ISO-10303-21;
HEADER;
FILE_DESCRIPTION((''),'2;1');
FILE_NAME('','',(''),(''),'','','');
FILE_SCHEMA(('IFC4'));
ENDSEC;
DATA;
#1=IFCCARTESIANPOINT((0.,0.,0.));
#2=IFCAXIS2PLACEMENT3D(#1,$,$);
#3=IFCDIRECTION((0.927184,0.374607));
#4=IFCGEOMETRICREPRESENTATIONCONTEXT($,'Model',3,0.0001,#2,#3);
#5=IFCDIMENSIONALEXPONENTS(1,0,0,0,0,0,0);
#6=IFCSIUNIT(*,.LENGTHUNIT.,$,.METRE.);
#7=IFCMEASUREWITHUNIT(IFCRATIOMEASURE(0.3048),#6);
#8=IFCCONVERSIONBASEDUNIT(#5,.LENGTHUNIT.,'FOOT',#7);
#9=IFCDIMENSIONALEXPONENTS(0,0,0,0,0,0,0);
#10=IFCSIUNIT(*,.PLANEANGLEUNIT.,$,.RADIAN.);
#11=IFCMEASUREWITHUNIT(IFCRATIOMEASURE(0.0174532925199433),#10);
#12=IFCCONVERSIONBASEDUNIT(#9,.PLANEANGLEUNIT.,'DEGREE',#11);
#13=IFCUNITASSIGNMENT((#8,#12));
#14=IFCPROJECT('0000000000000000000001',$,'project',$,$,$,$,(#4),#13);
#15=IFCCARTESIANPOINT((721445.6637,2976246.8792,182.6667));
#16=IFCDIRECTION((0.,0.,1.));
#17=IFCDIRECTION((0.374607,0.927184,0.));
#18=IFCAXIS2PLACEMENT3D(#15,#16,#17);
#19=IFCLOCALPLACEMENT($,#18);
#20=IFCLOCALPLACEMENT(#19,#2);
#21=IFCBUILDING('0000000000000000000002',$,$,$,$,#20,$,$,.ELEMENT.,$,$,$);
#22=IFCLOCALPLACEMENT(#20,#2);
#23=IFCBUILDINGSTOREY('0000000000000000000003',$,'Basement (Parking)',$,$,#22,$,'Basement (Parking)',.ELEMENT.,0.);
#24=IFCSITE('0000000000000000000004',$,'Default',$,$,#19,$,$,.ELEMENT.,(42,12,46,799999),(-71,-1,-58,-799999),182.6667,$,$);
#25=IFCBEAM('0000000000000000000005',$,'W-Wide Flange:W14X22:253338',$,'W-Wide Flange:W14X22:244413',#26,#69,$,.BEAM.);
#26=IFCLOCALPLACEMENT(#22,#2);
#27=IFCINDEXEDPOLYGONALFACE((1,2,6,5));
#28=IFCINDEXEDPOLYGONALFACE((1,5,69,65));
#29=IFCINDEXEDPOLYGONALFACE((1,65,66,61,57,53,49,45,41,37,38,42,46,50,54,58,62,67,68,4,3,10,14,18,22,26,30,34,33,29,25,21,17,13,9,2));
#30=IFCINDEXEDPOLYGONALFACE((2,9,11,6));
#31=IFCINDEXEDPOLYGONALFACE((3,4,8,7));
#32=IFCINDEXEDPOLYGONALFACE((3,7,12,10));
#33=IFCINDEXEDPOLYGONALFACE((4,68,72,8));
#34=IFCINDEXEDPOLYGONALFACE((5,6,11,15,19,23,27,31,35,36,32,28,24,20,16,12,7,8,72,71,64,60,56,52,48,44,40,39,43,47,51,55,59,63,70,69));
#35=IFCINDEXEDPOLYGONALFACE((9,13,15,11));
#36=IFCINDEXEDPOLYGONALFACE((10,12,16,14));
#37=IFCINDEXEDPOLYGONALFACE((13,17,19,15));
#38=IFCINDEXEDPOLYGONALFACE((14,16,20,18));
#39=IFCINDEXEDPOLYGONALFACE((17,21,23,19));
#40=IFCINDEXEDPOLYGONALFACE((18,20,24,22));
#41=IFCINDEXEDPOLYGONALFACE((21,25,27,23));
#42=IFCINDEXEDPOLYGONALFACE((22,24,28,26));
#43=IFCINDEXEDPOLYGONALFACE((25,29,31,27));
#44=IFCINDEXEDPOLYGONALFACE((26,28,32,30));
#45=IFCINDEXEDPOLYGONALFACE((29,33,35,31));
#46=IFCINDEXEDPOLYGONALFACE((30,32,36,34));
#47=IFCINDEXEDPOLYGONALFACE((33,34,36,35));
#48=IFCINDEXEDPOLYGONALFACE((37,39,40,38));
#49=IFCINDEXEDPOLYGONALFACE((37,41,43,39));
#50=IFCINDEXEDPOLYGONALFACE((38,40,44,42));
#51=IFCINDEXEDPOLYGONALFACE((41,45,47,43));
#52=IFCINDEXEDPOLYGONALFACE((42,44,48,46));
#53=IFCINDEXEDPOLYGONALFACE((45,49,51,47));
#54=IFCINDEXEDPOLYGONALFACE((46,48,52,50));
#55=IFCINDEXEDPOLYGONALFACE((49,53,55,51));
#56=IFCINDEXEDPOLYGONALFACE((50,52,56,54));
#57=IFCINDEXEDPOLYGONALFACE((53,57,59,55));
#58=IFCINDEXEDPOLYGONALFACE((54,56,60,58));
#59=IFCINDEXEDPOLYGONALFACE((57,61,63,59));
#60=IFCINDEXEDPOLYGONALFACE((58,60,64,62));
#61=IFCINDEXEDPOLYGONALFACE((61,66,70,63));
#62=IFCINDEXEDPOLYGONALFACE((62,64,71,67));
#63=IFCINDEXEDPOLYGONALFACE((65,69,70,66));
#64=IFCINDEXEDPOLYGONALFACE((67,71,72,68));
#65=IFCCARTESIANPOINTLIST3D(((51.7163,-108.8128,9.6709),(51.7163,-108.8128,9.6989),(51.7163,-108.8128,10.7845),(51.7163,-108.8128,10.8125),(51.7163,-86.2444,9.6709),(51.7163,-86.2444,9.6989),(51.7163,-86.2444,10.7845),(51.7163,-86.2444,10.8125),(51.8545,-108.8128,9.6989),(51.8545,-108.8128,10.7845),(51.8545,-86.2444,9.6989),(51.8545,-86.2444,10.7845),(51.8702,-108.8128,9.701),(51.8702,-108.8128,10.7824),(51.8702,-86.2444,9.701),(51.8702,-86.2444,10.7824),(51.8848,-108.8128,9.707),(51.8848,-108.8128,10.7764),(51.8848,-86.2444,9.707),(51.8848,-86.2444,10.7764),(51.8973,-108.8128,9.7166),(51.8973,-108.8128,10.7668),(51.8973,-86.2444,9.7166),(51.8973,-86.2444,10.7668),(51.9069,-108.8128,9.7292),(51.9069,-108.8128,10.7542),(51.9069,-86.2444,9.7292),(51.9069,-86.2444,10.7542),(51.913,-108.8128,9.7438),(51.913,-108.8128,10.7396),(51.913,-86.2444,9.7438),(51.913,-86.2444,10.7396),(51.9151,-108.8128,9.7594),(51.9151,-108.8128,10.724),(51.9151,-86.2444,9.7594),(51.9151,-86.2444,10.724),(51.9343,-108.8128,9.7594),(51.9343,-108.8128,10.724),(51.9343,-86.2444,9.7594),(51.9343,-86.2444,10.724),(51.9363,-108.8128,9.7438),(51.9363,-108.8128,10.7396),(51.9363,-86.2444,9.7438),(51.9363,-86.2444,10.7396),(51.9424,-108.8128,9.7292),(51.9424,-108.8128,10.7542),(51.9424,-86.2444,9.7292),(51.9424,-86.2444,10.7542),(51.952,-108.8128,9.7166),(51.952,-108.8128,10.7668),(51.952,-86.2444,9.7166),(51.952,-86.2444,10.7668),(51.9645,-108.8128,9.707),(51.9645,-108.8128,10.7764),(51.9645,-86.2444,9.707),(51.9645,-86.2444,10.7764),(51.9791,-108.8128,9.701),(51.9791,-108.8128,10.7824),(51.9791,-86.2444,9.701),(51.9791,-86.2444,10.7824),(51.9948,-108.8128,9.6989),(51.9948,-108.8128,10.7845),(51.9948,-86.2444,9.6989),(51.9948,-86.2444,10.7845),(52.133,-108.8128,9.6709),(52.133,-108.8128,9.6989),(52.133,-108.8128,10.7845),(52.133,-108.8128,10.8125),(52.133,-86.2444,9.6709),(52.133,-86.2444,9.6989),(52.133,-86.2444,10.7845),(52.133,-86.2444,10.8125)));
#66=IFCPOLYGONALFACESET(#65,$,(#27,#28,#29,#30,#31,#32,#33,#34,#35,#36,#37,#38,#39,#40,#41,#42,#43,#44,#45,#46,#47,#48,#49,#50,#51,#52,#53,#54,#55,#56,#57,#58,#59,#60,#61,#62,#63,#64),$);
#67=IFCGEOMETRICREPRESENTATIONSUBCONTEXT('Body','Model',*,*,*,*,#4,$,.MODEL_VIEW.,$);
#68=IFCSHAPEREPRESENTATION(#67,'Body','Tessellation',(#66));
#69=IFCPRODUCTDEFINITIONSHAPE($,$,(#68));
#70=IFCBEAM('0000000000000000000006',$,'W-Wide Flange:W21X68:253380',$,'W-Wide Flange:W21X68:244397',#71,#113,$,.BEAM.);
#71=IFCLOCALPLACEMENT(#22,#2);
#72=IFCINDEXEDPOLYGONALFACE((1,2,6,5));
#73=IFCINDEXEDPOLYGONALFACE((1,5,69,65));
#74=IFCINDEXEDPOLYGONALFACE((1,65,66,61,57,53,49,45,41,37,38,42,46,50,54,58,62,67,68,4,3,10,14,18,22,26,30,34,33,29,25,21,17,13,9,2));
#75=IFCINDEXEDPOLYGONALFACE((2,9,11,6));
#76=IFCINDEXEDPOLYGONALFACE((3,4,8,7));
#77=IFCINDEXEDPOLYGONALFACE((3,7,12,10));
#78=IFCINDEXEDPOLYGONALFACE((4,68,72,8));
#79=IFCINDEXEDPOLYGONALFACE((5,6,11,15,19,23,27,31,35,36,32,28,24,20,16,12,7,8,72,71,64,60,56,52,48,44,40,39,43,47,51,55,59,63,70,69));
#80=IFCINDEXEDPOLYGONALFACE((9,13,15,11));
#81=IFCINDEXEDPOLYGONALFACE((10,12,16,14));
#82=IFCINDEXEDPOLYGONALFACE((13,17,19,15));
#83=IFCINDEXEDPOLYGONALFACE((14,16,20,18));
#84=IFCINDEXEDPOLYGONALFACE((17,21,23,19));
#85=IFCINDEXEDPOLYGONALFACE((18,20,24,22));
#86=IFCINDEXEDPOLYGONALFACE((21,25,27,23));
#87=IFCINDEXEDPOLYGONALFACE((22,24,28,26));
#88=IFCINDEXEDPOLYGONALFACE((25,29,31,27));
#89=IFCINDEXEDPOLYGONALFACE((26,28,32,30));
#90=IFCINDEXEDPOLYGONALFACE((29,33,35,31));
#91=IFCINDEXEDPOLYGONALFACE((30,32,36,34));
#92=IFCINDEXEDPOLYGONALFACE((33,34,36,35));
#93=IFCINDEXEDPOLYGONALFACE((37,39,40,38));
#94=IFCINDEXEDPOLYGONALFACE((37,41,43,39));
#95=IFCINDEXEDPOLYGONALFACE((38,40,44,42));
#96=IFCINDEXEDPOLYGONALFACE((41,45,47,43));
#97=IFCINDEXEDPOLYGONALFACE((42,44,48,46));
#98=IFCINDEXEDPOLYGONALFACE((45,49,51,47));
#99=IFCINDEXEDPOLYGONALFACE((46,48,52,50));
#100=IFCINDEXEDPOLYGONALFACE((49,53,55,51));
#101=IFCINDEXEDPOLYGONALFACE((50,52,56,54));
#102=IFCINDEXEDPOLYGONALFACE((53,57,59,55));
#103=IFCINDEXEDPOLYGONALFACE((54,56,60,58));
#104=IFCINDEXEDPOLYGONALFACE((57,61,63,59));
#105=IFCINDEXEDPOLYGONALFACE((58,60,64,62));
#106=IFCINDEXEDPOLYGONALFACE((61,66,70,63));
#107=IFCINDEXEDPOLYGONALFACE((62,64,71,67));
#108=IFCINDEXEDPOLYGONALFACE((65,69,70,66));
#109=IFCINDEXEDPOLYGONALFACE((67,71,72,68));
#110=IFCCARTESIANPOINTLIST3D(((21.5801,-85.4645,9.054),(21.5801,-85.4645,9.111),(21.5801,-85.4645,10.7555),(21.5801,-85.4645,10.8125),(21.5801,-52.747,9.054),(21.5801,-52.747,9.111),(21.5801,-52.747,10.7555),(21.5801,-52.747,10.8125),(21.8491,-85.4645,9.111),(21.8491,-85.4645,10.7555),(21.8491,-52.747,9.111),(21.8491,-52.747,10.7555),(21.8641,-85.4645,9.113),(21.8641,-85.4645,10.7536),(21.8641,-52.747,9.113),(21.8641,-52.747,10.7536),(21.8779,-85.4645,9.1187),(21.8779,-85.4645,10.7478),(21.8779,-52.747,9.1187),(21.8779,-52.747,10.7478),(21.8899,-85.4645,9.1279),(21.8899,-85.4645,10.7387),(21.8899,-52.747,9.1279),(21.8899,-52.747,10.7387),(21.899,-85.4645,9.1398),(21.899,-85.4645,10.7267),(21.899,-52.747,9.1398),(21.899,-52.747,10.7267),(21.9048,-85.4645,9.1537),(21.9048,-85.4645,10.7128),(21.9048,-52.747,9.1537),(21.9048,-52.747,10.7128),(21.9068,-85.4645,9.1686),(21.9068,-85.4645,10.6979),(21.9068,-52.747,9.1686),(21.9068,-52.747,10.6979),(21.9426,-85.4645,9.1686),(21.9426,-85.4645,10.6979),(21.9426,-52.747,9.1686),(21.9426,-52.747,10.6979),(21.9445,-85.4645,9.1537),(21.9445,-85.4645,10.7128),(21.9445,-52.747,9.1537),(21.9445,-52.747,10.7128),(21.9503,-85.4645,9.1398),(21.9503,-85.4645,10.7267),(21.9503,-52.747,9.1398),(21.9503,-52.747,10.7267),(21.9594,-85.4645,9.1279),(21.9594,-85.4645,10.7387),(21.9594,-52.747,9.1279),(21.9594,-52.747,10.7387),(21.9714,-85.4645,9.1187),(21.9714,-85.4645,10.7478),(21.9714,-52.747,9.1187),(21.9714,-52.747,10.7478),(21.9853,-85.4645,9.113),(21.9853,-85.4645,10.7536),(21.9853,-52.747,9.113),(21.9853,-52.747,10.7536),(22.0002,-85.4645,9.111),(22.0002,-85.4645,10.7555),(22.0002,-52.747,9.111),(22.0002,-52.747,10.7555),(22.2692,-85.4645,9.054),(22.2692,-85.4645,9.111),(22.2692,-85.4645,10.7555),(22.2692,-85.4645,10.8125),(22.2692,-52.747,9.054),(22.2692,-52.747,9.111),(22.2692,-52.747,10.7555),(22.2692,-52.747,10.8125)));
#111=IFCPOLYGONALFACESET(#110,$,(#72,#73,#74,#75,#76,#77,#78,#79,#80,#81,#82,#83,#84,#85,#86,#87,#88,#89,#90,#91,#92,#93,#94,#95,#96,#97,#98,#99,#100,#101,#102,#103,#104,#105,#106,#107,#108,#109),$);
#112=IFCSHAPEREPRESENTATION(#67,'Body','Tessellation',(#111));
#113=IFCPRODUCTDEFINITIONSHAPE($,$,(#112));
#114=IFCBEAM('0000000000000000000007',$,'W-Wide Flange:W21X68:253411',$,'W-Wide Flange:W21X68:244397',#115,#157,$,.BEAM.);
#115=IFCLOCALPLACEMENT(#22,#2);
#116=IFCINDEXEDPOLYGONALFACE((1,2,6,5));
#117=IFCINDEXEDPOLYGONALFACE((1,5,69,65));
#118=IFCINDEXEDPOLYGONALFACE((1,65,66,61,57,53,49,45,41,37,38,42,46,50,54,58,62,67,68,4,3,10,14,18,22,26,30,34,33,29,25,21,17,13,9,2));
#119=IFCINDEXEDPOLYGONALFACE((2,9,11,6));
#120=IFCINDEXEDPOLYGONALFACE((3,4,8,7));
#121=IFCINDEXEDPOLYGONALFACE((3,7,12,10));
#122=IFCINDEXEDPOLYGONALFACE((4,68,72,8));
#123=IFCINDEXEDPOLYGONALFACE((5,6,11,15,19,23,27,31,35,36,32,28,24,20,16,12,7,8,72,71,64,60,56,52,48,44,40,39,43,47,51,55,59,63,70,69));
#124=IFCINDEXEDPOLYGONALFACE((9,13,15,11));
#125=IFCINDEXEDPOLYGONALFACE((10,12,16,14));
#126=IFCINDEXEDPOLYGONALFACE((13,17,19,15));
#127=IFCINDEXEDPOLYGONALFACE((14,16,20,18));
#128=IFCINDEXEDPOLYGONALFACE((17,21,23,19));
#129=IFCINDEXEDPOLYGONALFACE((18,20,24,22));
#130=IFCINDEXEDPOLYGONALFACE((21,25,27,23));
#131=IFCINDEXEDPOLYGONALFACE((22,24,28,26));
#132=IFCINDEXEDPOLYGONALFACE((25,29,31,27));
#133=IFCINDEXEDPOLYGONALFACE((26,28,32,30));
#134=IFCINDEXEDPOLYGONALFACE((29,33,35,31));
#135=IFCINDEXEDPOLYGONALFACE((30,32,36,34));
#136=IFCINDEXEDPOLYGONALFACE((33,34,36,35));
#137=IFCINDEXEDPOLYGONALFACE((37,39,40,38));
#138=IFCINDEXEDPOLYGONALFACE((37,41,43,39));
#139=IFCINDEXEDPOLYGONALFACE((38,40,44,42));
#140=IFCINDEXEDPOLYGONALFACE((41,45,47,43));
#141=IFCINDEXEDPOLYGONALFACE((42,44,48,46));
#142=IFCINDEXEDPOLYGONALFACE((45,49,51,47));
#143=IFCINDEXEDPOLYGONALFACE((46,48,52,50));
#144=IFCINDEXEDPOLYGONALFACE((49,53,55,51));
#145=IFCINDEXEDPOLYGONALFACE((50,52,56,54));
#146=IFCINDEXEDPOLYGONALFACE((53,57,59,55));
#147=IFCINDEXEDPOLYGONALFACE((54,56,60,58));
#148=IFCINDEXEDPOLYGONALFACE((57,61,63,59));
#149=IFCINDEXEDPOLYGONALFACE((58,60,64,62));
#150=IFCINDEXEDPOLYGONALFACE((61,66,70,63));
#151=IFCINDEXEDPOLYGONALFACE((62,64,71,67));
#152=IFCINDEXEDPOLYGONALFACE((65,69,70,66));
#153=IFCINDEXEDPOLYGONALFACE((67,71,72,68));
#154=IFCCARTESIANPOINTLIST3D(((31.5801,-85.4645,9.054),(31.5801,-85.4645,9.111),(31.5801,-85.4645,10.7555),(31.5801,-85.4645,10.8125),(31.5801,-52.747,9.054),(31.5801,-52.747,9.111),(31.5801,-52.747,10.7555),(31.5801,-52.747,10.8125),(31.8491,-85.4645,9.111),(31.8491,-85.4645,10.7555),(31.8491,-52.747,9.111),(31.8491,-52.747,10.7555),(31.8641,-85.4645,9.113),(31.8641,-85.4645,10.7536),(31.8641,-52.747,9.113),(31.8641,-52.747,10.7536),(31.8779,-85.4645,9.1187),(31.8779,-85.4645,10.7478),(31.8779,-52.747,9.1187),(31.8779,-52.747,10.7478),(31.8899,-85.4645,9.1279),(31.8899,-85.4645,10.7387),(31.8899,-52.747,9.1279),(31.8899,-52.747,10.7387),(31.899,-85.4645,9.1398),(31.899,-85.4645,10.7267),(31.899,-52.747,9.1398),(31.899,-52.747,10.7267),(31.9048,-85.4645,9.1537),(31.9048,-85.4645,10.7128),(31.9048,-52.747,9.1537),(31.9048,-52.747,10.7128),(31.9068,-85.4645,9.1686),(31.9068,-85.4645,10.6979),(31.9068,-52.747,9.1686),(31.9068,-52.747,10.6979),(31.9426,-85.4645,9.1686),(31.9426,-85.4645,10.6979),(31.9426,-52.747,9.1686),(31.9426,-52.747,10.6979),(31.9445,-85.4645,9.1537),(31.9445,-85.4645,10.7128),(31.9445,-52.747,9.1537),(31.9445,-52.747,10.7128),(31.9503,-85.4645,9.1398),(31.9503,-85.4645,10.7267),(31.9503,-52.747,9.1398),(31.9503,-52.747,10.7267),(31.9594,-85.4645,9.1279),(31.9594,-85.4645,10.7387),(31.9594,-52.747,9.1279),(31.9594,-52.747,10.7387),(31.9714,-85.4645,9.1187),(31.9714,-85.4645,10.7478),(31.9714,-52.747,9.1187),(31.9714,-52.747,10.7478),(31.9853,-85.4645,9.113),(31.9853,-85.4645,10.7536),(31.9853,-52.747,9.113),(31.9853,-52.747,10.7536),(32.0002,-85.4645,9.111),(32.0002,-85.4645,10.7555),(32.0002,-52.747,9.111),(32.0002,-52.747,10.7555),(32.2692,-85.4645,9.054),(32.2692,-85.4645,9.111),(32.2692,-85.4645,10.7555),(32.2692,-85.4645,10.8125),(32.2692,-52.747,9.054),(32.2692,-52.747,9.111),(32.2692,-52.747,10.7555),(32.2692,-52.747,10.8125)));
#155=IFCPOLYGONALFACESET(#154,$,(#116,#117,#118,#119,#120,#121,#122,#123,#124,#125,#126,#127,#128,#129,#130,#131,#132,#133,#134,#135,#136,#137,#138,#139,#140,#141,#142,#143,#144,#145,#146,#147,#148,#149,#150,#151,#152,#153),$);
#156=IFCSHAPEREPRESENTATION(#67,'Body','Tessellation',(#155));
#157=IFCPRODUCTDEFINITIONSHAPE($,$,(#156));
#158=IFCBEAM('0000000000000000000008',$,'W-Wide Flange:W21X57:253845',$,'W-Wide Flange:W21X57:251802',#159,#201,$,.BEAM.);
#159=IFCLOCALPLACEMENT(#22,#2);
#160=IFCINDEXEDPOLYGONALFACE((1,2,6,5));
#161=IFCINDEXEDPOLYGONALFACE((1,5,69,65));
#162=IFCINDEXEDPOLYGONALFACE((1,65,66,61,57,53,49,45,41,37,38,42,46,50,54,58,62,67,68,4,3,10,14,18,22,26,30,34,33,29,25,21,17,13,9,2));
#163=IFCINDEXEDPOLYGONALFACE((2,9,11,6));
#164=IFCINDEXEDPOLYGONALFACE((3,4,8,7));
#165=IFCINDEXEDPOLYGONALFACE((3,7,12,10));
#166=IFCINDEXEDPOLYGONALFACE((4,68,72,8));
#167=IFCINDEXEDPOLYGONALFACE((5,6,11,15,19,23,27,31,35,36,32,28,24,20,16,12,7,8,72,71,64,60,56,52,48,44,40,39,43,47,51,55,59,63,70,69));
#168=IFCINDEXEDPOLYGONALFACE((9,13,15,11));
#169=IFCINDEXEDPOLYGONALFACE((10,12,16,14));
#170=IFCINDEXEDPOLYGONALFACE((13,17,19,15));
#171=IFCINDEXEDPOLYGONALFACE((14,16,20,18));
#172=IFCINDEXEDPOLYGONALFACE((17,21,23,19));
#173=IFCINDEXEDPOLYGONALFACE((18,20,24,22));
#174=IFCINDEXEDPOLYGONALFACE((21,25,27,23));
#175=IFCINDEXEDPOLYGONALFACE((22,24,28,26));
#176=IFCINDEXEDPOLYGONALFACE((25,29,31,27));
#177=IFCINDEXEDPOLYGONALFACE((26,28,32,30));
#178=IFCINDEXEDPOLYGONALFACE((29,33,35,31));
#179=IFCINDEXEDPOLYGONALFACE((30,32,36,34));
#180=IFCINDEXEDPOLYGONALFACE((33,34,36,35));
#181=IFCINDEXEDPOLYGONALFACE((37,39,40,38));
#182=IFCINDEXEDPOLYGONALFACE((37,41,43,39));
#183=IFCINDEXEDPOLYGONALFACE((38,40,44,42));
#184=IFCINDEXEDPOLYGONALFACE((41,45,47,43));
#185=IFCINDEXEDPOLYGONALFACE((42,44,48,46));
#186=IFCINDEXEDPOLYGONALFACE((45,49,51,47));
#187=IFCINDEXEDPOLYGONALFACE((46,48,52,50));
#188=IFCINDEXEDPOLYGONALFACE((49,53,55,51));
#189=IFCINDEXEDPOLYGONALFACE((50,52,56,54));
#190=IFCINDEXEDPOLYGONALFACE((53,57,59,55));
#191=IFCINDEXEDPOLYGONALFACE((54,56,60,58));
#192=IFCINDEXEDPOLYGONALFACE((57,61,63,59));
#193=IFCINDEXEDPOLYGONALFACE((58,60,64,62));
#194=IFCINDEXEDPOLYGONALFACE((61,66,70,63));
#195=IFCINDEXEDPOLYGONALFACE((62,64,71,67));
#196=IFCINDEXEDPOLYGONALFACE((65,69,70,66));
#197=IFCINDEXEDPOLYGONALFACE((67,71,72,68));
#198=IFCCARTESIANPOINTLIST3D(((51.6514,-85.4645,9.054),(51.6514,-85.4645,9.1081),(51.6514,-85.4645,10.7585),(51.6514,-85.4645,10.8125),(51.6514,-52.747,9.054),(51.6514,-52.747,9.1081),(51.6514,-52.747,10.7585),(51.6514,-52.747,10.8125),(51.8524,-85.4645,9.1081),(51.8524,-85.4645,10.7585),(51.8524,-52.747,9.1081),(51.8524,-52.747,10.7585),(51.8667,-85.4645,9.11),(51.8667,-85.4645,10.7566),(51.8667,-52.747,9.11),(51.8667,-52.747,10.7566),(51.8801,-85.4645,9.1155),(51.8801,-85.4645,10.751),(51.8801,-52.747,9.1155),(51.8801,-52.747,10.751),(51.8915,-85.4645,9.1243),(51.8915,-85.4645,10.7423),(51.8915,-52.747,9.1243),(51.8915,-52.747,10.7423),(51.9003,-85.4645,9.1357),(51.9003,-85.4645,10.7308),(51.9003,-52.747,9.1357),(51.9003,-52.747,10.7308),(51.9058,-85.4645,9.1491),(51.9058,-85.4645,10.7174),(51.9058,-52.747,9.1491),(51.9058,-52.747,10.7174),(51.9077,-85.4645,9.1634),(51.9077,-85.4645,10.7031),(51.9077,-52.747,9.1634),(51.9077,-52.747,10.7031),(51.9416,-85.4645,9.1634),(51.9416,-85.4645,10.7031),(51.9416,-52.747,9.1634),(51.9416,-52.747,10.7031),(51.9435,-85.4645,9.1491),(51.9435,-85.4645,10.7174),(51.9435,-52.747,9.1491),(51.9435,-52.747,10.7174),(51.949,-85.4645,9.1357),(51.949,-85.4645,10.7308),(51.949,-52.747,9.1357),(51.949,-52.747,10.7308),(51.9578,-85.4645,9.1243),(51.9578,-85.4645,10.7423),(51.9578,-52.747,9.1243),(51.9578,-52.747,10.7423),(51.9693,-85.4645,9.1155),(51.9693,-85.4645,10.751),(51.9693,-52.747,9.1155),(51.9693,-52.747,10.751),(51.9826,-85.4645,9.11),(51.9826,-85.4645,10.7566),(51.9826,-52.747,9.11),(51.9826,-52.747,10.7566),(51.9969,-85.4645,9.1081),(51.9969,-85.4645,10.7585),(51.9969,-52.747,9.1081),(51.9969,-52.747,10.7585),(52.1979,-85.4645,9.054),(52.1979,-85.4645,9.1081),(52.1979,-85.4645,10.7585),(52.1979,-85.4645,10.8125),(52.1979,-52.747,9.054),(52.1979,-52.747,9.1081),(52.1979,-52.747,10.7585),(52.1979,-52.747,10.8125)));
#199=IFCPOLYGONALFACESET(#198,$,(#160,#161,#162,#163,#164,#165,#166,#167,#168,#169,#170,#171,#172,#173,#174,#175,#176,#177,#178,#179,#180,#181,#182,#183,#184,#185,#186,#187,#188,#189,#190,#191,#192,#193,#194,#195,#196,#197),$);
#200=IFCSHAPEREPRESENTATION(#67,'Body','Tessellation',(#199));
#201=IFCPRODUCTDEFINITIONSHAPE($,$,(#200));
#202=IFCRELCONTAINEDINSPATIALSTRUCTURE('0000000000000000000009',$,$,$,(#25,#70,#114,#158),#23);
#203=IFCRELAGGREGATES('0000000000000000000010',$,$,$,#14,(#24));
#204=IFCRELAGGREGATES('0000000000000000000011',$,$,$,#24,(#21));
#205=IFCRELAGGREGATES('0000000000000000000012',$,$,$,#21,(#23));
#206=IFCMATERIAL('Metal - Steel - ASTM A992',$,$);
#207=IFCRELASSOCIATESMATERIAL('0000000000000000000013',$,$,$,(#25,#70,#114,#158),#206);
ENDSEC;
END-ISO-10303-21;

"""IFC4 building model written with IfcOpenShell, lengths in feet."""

from ifc_helpers import new_model, entity, si_unit, converted_unit, direction, frame, frame_2d, origin, place, context, subcontext, project, spatial, i_section, extrude, material, element, save


model = new_model("IFC4")

# Units and contexts
model_context = context("Model", 3, precision=0.0001, world=origin(), true_north=direction((0.927184, 0.374607)))
body_context = subcontext(model_context, "Body", "Model", "MODEL_VIEW")
ifc_project = project(units=[converted_unit("LENGTHUNIT", "FOOT", entity("IfcRatioMeasure", 0.3048), si_unit("LENGTHUNIT", "METRE"), dimensions=[1, 0, 0, 0, 0, 0, 0]), converted_unit("PLANEANGLEUNIT", "DEGREE", entity("IfcRatioMeasure", 0.0174532925199433), si_unit("PLANEANGLEUNIT", "RADIAN"), dimensions=[0, 0, 0, 0, 0, 0, 0])], contexts=[model_context])

# Site, building, storey
site_placement = place(None, frame((721445.6637, 2976246.8792, 182.6667), z_axis=(0.0, 0.0, 1.0), x_axis=(0.374607, 0.927184, 0.0)))
site = spatial("IfcSite", under=ifc_project, at=site_placement, Name="Default", CompositionType="ELEMENT", RefLatitude=(42, 12, 46, 799999), RefLongitude=(-71, -1, -58, -799999), RefElevation=182.6667)
building_placement = place(site_placement, origin())
building = spatial("IfcBuilding", under=site, at=building_placement, CompositionType="ELEMENT")
storey_placement = place(building_placement, origin())
storey = spatial("IfcBuildingStorey", under=building, at=storey_placement, Name="Basement (Parking)", LongName="Basement (Parking)", CompositionType="ELEMENT", Elevation=0.0)

# Shared definitions
ifc_material_1 = material(Name="Metal - Steel - ASTM A992")

# Beams
beam_1_placement = place(storey_placement, frame((51.9247, -85.8544, 10.8125), z_axis=(0.0, 0.0, 1.0), x_axis=(0.0, -1.0, 0.0)))
element("IfcBeam", 1, at=beam_1_placement, inside=storey, material=ifc_material_1, Name="W-Wide Flange:W14X22:253338", ObjectType="W-Wide Flange:W14X22:244413", PredefinedType="BEAM", context=body_context, shape_type="SweptSolid", body=[
    extrude(i_section(OverallWidth=0.4167, OverallDepth=1.1416, WebThickness=0.0192, FlangeThickness=0.028, FilletRadius=0.0605, at=frame_2d((0.0, 0.0), x_axis=(0.0, 1.0))), frame((0.39, 0.0, -0.5708), z_axis=(1.0, 0.0, 0.0), x_axis=(0.0, 0.0, -1.0)), (0.0, 0.0, 1.0), 22.5684),
])
beam_2_placement = place(storey_placement, frame((21.9247, -85.8544, 10.8125), z_axis=(0.0, 0.0, 1.0), x_axis=(0.0, 1.0, 0.0)))
element("IfcBeam", 2, at=beam_2_placement, inside=storey, material=ifc_material_1, Name="W-Wide Flange:W21X68:253380", ObjectType="W-Wide Flange:W21X68:244397", PredefinedType="BEAM", context=body_context, shape_type="SweptSolid", body=[
    extrude(i_section(OverallWidth=0.6891, OverallDepth=1.7585, WebThickness=0.0358, FlangeThickness=0.057, FilletRadius=0.0576, at=frame_2d((0.0, 0.0), x_axis=(0.0, 1.0))), frame((0.39, 0.0, -0.8792), z_axis=(1.0, 0.0, 0.0), x_axis=(0.0, 0.0, -1.0)), (0.0, 0.0, 1.0), 32.7174),
])
beam_3_placement = place(storey_placement, frame((31.9247, -85.8544, 10.8125), z_axis=(0.0, 0.0, 1.0), x_axis=(0.0, 1.0, 0.0)))
element("IfcBeam", 3, at=beam_3_placement, inside=storey, material=ifc_material_1, Name="W-Wide Flange:W21X68:253411", ObjectType="W-Wide Flange:W21X68:244397", PredefinedType="BEAM", context=body_context, shape_type="SweptSolid", body=[
    extrude(i_section(OverallWidth=0.6891, OverallDepth=1.7585, WebThickness=0.0358, FlangeThickness=0.057, FilletRadius=0.0576, at=frame_2d((0.0, 0.0), x_axis=(0.0, 1.0))), frame((0.39, 0.0, -0.8792), z_axis=(1.0, 0.0, 0.0), x_axis=(0.0, 0.0, -1.0)), (0.0, 0.0, 1.0), 32.7174),
])
beam_4_placement = place(storey_placement, frame((51.9247, -85.8544, 10.8125), z_axis=(0.0, 0.0, 1.0), x_axis=(0.0, 1.0, 0.0)))
element("IfcBeam", 4, at=beam_4_placement, inside=storey, material=ifc_material_1, Name="W-Wide Flange:W21X57:253845", ObjectType="W-Wide Flange:W21X57:251802", PredefinedType="BEAM", context=body_context, shape_type="SweptSolid", body=[
    extrude(i_section(OverallWidth=0.5465, OverallDepth=1.7585, WebThickness=0.0339, FlangeThickness=0.054, FilletRadius=0.0553, at=frame_2d((0.0, 0.0), x_axis=(0.0, 1.0))), frame((0.39, 0.0, -0.8792), z_axis=(1.0, 0.0, 0.0), x_axis=(0.0, 0.0, -1.0)), (0.0, 0.0, 1.0), 32.7174),
])

save(model, "model.ifc")
